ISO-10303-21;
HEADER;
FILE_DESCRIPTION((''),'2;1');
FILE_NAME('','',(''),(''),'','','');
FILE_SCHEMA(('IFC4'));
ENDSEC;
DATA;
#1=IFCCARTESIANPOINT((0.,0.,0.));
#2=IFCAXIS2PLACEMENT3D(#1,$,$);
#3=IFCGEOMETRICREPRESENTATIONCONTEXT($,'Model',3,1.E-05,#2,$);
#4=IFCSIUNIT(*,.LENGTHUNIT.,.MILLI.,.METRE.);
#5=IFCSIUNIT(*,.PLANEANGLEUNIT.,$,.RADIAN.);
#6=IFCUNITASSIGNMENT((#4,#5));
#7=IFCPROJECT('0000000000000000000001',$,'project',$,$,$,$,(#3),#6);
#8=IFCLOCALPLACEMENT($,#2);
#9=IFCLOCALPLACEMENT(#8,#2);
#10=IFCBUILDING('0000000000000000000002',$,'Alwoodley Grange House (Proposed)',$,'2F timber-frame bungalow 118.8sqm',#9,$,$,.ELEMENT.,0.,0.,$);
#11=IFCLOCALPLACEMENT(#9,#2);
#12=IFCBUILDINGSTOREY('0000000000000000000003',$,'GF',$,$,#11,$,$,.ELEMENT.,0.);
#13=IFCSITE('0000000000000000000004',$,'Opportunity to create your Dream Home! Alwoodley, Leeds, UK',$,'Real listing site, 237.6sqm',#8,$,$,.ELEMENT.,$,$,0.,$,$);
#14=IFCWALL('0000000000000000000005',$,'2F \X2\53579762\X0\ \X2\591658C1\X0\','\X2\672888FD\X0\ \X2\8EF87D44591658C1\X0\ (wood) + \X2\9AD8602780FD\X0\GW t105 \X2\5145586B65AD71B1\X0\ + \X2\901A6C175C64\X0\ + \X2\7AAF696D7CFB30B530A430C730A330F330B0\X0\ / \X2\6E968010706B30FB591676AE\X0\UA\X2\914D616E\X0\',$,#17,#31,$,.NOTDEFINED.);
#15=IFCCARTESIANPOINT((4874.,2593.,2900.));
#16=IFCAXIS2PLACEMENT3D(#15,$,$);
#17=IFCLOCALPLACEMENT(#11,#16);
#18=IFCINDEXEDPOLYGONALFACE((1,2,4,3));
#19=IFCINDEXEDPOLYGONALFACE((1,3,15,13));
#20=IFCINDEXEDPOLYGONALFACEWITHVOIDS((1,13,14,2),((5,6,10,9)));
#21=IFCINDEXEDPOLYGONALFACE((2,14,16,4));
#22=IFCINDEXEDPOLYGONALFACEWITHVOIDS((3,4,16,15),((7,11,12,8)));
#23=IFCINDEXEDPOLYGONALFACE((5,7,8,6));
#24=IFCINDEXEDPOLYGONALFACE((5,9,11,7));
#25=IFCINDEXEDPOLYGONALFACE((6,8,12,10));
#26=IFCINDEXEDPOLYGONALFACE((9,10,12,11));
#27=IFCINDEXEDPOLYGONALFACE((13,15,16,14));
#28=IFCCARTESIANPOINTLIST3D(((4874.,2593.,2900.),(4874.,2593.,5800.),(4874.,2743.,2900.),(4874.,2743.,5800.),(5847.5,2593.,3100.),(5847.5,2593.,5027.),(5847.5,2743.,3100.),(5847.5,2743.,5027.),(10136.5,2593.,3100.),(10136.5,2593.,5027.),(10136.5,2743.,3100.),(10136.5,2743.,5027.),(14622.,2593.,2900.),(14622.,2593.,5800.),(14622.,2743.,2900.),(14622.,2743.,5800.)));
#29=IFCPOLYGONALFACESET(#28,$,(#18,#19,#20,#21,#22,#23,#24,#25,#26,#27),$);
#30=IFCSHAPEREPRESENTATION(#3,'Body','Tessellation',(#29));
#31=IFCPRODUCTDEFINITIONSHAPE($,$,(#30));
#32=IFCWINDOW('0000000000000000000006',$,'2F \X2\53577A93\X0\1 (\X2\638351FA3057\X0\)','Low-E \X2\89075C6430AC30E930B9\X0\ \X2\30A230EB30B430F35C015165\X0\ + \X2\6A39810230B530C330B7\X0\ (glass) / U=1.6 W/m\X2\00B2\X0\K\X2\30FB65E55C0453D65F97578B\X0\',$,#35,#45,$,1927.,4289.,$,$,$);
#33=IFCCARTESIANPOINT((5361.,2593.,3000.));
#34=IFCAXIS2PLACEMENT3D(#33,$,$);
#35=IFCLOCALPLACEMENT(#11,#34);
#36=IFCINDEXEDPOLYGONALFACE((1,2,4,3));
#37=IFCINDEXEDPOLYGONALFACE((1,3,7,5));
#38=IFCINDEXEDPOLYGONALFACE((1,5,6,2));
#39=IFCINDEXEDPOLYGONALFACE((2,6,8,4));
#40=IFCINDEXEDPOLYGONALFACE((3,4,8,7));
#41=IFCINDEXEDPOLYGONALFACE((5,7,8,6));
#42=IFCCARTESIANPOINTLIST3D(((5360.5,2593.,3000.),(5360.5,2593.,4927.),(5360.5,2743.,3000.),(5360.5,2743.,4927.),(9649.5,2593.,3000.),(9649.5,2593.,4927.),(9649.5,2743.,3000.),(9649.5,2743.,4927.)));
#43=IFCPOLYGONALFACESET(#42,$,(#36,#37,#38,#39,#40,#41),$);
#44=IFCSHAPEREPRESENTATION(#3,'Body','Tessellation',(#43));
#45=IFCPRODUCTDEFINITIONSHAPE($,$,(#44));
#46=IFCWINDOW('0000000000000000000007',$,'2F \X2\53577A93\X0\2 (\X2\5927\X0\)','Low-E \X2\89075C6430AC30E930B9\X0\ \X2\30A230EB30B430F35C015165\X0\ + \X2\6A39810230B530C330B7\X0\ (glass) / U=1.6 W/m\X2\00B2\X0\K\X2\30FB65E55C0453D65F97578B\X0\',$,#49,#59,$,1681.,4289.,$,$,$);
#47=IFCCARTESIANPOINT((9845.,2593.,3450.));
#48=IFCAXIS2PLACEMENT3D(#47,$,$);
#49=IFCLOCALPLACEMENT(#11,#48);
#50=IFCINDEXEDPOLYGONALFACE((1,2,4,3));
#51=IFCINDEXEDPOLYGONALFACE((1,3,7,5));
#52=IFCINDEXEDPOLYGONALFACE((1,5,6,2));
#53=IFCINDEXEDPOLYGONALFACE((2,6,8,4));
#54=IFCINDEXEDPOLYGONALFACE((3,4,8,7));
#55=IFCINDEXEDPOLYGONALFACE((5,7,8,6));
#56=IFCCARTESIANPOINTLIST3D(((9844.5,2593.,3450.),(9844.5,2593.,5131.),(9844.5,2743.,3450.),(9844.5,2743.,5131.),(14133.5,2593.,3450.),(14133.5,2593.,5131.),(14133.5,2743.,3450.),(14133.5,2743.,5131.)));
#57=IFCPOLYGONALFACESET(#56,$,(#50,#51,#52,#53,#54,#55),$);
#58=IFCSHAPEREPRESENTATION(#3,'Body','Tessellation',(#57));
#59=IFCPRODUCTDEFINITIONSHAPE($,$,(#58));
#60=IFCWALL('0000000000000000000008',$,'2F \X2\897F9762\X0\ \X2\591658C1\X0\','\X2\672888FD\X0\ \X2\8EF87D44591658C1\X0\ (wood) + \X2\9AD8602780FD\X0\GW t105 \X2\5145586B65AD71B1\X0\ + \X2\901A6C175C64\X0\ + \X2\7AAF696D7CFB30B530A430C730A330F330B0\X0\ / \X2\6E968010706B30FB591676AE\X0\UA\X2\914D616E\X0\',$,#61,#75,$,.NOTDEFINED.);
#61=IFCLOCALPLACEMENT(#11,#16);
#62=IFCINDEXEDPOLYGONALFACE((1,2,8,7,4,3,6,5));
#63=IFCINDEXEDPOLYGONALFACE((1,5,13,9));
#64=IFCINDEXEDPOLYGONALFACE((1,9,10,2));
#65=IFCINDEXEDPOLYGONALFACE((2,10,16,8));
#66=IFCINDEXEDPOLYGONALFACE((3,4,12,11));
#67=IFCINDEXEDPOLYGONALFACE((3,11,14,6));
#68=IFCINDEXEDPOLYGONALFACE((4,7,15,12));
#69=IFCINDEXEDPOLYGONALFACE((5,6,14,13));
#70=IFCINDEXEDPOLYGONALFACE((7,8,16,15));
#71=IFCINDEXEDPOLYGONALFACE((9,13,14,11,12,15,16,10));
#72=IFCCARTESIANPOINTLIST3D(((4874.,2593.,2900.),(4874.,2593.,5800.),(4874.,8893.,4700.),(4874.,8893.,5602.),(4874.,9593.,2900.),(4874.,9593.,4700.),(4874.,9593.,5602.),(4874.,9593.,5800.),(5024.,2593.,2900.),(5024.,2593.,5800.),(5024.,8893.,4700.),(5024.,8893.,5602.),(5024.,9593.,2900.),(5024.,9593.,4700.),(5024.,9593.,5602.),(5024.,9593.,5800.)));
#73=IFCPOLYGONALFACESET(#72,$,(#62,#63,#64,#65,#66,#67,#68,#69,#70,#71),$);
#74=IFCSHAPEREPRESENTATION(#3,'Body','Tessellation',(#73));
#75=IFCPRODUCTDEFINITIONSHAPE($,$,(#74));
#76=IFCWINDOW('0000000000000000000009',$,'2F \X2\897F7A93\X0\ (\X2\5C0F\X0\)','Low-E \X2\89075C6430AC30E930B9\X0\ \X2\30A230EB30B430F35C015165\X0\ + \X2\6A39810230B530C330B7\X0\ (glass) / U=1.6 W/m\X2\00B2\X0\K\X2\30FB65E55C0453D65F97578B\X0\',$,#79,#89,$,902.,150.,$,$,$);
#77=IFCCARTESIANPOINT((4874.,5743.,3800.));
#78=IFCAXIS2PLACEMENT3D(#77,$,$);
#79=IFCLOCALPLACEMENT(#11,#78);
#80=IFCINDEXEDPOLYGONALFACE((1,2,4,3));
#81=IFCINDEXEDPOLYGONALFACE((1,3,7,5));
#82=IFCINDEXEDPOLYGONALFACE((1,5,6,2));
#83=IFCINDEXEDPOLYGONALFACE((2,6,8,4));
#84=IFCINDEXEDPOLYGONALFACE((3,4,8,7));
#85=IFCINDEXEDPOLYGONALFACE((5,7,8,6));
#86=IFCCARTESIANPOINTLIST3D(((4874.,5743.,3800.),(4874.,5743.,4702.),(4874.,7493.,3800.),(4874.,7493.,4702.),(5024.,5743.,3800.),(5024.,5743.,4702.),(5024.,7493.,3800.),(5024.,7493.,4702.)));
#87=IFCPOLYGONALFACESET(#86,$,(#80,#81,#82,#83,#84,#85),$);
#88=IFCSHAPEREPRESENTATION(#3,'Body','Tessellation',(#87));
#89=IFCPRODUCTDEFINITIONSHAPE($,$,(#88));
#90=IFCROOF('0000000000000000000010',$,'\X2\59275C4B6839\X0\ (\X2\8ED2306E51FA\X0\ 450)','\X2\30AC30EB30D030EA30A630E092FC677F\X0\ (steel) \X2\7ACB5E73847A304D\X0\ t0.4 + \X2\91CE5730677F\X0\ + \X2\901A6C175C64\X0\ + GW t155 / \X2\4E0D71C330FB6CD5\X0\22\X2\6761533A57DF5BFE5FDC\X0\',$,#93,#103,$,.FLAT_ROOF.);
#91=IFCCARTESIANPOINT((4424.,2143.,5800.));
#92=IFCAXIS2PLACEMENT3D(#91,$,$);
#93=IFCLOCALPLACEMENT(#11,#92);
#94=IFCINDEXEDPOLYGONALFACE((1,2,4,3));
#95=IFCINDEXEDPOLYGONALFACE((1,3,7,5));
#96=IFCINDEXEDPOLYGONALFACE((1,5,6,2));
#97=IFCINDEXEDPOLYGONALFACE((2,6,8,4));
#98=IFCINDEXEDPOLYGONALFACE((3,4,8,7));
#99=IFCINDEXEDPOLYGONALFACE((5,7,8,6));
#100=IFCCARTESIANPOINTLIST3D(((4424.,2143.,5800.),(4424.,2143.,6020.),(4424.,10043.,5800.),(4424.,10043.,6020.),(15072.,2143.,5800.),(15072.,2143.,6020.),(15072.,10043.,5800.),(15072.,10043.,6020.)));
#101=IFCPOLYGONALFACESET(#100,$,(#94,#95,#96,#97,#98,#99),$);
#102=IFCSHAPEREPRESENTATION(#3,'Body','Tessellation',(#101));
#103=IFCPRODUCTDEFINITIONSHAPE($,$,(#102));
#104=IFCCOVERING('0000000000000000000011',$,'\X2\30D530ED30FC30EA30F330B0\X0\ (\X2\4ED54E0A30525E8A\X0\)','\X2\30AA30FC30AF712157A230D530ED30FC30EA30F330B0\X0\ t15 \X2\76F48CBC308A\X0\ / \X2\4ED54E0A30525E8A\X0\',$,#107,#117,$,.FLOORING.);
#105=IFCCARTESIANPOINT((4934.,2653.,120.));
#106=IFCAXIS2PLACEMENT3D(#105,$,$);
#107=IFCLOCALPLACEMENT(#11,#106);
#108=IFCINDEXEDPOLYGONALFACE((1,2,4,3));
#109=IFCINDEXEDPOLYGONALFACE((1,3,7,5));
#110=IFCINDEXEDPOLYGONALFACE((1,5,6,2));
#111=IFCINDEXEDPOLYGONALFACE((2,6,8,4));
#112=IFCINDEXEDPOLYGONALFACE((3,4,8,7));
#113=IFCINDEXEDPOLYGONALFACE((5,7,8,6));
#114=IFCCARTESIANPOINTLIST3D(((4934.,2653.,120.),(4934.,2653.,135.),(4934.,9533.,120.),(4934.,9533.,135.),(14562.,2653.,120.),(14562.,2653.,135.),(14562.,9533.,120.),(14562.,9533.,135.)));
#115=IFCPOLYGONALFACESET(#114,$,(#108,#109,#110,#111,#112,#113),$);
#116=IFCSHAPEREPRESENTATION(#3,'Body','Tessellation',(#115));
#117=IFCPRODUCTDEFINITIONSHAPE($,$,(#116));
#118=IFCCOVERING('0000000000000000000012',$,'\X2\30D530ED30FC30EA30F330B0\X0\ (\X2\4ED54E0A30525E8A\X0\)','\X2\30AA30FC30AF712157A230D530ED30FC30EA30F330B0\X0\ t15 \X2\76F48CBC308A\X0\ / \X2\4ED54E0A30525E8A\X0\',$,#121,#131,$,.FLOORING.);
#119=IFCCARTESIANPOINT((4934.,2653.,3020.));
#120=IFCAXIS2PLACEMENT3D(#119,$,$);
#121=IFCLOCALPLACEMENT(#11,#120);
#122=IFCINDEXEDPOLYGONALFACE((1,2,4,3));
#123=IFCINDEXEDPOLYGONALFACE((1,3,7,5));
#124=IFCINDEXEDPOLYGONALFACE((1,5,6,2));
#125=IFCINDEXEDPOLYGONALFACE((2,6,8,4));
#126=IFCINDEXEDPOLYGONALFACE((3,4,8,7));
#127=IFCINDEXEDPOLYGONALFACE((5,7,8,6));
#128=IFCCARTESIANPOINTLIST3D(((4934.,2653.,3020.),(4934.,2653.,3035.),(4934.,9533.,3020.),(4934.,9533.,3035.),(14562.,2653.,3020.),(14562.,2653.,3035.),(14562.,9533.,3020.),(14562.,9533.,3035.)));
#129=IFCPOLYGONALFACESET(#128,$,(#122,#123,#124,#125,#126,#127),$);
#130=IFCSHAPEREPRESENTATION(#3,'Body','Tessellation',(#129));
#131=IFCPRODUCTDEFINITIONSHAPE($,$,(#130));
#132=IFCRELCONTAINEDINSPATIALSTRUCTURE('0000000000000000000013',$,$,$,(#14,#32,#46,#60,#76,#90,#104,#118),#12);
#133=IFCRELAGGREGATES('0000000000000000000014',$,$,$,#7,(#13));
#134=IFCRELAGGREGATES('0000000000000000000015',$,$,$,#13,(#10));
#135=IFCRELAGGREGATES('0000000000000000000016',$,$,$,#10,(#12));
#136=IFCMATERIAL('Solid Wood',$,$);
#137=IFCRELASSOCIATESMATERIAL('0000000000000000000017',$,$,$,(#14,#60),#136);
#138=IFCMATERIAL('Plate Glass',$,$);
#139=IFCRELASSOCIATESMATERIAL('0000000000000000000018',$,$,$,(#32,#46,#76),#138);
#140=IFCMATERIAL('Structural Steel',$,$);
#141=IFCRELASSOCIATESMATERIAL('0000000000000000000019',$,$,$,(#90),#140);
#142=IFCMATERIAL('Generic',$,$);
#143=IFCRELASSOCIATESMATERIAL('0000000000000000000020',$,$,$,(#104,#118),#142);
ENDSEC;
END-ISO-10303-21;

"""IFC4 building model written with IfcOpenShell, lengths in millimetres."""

from ifc_helpers import new_model, si_unit, frame, frame_2d, origin, place, context, project, spatial, rectangle, extrude, material, element, fill, save


model = new_model("IFC4")

# Units and contexts
model_context = context("Model", 3, precision=1e-05, world=origin())
ifc_project = project(units=[si_unit("LENGTHUNIT", "METRE", prefix="MILLI"), si_unit("PLANEANGLEUNIT", "RADIAN")], contexts=[model_context])

# Site, building, storey
site_placement = place(None, origin())
site = spatial("IfcSite", under=ifc_project, at=site_placement, Name="Opportunity to create your Dream Home! Alwoodley, Leeds, UK", ObjectType="Real listing site, 237.6sqm", CompositionType="ELEMENT", RefElevation=0.0)
building_placement = place(site_placement, origin())
building = spatial("IfcBuilding", under=site, at=building_placement, Name="Alwoodley Grange House (Proposed)", ObjectType="2F timber-frame bungalow 118.8sqm", CompositionType="ELEMENT", ElevationOfRefHeight=0.0, ElevationOfTerrain=0.0)
storey_placement = place(building_placement, origin())
storey = spatial("IfcBuildingStorey", under=building, at=storey_placement, Name="GF", CompositionType="ELEMENT", Elevation=0.0)

# Shared definitions
ifc_material_1 = material(Name="Solid Wood")

# Shared definitions
ifc_material_2 = material(Name="Plate Glass")

# Wall, openings, windows
wall_1_placement = place(storey_placement, frame((4874.0, 2593.0, 2900.0)))
wall_1 = element("IfcWall", 1, at=wall_1_placement, inside=storey, material=ifc_material_1, Name="2F 南面 外壁", Description="木製 軸組外壁 (wood) + 高性能GW t105 充填断熱 + 通気層 + 窯業系サイディング / 準耐火・外皮UA配慮", PredefinedType="NOTDEFINED", context=model_context, shape_type="SweptSolid", body=[
    extrude(rectangle(XDim=9748.0, YDim=150.0, at=frame_2d((4874.0, 75.0))), frame((4874.0, 2593.0, 2900.0)), (0.0, 0.0, 1.0), 2900.0),
])
opening_1_placement = place(storey_placement, frame((5361.0, 2593.0, 3000.0)))
opening_1 = element("IfcOpeningElement", 2, at=opening_1_placement, cuts=wall_1, PredefinedType="NOTDEFINED", context=model_context, shape_type="SweptSolid", body=[
    extrude(rectangle(XDim=4289.0, YDim=150.0, at=frame_2d((2144.0, 75.0))), frame((5361.0, 2593.0, 3000.0)), (0.0, 0.0, 1.0), 1927.0),
])
opening_2_placement = place(storey_placement, frame((9845.0, 2593.0, 3450.0)))
opening_2 = element("IfcOpeningElement", 3, at=opening_2_placement, cuts=wall_1, PredefinedType="NOTDEFINED", context=model_context, shape_type="SweptSolid", body=[
    extrude(rectangle(XDim=4289.0, YDim=150.0, at=frame_2d((2144.0, 75.0))), frame((9845.0, 2593.0, 3450.0)), (0.0, 0.0, 1.0), 1681.0),
])
window_1_placement = place(storey_placement, frame((5361.0, 2593.0, 3000.0)))
window_1 = element("IfcWindow", 4, at=window_1_placement, inside=storey, material=ifc_material_2, Name="2F 南窓1 (掃出し)", Description="Low-E 複層ガラス アルゴン封入 + 樹脂サッシ (glass) / U=1.6 W/m²K・日射取得型", OverallHeight=1927.0, OverallWidth=4289.0, context=model_context, shape_type="SweptSolid", body=[
    extrude(rectangle(XDim=4289.0, YDim=150.0, at=frame_2d((2144.0, 75.0))), frame((5361.0, 2593.0, 3000.0)), (0.0, 0.0, 1.0), 1927.0),
])
fill(opening_1, window_1)
window_2_placement = place(storey_placement, frame((9845.0, 2593.0, 3450.0)))
window_2 = element("IfcWindow", 5, at=window_2_placement, inside=storey, material=ifc_material_2, Name="2F 南窓2 (大)", Description="Low-E 複層ガラス アルゴン封入 + 樹脂サッシ (glass) / U=1.6 W/m²K・日射取得型", OverallHeight=1681.0, OverallWidth=4289.0, context=model_context, shape_type="SweptSolid", body=[
    extrude(rectangle(XDim=4289.0, YDim=150.0, at=frame_2d((2144.0, 75.0))), frame((9845.0, 2593.0, 3450.0)), (0.0, 0.0, 1.0), 1681.0),
])
fill(opening_2, window_2)

# Wall, opening, window
wall_2_placement = place(storey_placement, frame((4874.0, 2593.0, 2900.0)))
wall_2 = element("IfcWall", 6, at=wall_2_placement, inside=storey, material=ifc_material_1, Name="2F 西面 外壁", Description="木製 軸組外壁 (wood) + 高性能GW t105 充填断熱 + 通気層 + 窯業系サイディング / 準耐火・外皮UA配慮", PredefinedType="NOTDEFINED", context=model_context, shape_type="SweptSolid", body=[
    extrude(rectangle(XDim=150.0, YDim=7000.0, at=frame_2d((75.0, 3500.0))), frame((4874.0, 2593.0, 2900.0)), (0.0, 0.0, 1.0), 2900.0),
])
opening_3_placement = place(storey_placement, frame((4874.0, 5743.0, 3800.0)))
opening_3 = element("IfcOpeningElement", 7, at=opening_3_placement, cuts=wall_2, PredefinedType="NOTDEFINED", context=model_context, shape_type="SweptSolid", body=[
    extrude(rectangle(XDim=150.0, YDim=1750.0, at=frame_2d((75.0, 875.0))), frame((4874.0, 5743.0, 3800.0)), (0.0, 0.0, 1.0), 902.0),
])
window_3_placement = place(storey_placement, frame((4874.0, 5743.0, 3800.0)))
window_3 = element("IfcWindow", 8, at=window_3_placement, inside=storey, material=ifc_material_2, Name="2F 西窓 (小)", Description="Low-E 複層ガラス アルゴン封入 + 樹脂サッシ (glass) / U=1.6 W/m²K・日射取得型", OverallHeight=902.0, OverallWidth=150.0, context=model_context, shape_type="SweptSolid", body=[
    extrude(rectangle(XDim=150.0, YDim=1750.0, at=frame_2d((75.0, 875.0))), frame((4874.0, 5743.0, 3800.0)), (0.0, 0.0, 1.0), 902.0),
])
fill(opening_3, window_3)

# Roof
ifc_material_3 = material(Name="Structural Steel")
roof_placement = place(storey_placement, frame((4424.0, 2143.0, 5800.0)))
element("IfcRoof", 9, at=roof_placement, inside=storey, material=ifc_material_3, Name="大屋根 (軒の出 450)", Description="ガルバリウム鋼板 (steel) 立平葺き t0.4 + 野地板 + 通気層 + GW t155 / 不燃・法22条区域対応", PredefinedType="FLAT_ROOF", context=model_context, shape_type="SweptSolid", body=[
    extrude(rectangle(XDim=10648.0, YDim=7900.0, at=frame_2d((5324.0, 3950.0))), frame((4424.0, 2143.0, 5800.0)), (0.0, 0.0, 1.0), 220.0),
])

# Coverings
ifc_material_4 = material(Name="Generic")
covering_1_placement = place(storey_placement, frame((4934.0, 2653.0, 120.0)))
element("IfcCovering", 10, at=covering_1_placement, inside=storey, material=ifc_material_4, Name="フローリング (仕上げ床)", Description="オーク無垢フローリング t15 直貼り / 仕上げ床", PredefinedType="FLOORING", context=model_context, shape_type="SweptSolid", body=[
    extrude(rectangle(XDim=9628.0, YDim=6880.0, at=frame_2d((4814.0, 3440.0))), frame((4934.0, 2653.0, 120.0)), (0.0, 0.0, 1.0), 15.0),
])
covering_2_placement = place(storey_placement, frame((4934.0, 2653.0, 3020.0)))
element("IfcCovering", 11, at=covering_2_placement, inside=storey, material=ifc_material_4, Name="フローリング (仕上げ床)", Description="オーク無垢フローリング t15 直貼り / 仕上げ床", PredefinedType="FLOORING", context=model_context, shape_type="SweptSolid", body=[
    extrude(rectangle(XDim=9628.0, YDim=6880.0, at=frame_2d((4814.0, 3440.0))), frame((4934.0, 2653.0, 3020.0)), (0.0, 0.0, 1.0), 15.0),
])

save(model, "model.ifc")
